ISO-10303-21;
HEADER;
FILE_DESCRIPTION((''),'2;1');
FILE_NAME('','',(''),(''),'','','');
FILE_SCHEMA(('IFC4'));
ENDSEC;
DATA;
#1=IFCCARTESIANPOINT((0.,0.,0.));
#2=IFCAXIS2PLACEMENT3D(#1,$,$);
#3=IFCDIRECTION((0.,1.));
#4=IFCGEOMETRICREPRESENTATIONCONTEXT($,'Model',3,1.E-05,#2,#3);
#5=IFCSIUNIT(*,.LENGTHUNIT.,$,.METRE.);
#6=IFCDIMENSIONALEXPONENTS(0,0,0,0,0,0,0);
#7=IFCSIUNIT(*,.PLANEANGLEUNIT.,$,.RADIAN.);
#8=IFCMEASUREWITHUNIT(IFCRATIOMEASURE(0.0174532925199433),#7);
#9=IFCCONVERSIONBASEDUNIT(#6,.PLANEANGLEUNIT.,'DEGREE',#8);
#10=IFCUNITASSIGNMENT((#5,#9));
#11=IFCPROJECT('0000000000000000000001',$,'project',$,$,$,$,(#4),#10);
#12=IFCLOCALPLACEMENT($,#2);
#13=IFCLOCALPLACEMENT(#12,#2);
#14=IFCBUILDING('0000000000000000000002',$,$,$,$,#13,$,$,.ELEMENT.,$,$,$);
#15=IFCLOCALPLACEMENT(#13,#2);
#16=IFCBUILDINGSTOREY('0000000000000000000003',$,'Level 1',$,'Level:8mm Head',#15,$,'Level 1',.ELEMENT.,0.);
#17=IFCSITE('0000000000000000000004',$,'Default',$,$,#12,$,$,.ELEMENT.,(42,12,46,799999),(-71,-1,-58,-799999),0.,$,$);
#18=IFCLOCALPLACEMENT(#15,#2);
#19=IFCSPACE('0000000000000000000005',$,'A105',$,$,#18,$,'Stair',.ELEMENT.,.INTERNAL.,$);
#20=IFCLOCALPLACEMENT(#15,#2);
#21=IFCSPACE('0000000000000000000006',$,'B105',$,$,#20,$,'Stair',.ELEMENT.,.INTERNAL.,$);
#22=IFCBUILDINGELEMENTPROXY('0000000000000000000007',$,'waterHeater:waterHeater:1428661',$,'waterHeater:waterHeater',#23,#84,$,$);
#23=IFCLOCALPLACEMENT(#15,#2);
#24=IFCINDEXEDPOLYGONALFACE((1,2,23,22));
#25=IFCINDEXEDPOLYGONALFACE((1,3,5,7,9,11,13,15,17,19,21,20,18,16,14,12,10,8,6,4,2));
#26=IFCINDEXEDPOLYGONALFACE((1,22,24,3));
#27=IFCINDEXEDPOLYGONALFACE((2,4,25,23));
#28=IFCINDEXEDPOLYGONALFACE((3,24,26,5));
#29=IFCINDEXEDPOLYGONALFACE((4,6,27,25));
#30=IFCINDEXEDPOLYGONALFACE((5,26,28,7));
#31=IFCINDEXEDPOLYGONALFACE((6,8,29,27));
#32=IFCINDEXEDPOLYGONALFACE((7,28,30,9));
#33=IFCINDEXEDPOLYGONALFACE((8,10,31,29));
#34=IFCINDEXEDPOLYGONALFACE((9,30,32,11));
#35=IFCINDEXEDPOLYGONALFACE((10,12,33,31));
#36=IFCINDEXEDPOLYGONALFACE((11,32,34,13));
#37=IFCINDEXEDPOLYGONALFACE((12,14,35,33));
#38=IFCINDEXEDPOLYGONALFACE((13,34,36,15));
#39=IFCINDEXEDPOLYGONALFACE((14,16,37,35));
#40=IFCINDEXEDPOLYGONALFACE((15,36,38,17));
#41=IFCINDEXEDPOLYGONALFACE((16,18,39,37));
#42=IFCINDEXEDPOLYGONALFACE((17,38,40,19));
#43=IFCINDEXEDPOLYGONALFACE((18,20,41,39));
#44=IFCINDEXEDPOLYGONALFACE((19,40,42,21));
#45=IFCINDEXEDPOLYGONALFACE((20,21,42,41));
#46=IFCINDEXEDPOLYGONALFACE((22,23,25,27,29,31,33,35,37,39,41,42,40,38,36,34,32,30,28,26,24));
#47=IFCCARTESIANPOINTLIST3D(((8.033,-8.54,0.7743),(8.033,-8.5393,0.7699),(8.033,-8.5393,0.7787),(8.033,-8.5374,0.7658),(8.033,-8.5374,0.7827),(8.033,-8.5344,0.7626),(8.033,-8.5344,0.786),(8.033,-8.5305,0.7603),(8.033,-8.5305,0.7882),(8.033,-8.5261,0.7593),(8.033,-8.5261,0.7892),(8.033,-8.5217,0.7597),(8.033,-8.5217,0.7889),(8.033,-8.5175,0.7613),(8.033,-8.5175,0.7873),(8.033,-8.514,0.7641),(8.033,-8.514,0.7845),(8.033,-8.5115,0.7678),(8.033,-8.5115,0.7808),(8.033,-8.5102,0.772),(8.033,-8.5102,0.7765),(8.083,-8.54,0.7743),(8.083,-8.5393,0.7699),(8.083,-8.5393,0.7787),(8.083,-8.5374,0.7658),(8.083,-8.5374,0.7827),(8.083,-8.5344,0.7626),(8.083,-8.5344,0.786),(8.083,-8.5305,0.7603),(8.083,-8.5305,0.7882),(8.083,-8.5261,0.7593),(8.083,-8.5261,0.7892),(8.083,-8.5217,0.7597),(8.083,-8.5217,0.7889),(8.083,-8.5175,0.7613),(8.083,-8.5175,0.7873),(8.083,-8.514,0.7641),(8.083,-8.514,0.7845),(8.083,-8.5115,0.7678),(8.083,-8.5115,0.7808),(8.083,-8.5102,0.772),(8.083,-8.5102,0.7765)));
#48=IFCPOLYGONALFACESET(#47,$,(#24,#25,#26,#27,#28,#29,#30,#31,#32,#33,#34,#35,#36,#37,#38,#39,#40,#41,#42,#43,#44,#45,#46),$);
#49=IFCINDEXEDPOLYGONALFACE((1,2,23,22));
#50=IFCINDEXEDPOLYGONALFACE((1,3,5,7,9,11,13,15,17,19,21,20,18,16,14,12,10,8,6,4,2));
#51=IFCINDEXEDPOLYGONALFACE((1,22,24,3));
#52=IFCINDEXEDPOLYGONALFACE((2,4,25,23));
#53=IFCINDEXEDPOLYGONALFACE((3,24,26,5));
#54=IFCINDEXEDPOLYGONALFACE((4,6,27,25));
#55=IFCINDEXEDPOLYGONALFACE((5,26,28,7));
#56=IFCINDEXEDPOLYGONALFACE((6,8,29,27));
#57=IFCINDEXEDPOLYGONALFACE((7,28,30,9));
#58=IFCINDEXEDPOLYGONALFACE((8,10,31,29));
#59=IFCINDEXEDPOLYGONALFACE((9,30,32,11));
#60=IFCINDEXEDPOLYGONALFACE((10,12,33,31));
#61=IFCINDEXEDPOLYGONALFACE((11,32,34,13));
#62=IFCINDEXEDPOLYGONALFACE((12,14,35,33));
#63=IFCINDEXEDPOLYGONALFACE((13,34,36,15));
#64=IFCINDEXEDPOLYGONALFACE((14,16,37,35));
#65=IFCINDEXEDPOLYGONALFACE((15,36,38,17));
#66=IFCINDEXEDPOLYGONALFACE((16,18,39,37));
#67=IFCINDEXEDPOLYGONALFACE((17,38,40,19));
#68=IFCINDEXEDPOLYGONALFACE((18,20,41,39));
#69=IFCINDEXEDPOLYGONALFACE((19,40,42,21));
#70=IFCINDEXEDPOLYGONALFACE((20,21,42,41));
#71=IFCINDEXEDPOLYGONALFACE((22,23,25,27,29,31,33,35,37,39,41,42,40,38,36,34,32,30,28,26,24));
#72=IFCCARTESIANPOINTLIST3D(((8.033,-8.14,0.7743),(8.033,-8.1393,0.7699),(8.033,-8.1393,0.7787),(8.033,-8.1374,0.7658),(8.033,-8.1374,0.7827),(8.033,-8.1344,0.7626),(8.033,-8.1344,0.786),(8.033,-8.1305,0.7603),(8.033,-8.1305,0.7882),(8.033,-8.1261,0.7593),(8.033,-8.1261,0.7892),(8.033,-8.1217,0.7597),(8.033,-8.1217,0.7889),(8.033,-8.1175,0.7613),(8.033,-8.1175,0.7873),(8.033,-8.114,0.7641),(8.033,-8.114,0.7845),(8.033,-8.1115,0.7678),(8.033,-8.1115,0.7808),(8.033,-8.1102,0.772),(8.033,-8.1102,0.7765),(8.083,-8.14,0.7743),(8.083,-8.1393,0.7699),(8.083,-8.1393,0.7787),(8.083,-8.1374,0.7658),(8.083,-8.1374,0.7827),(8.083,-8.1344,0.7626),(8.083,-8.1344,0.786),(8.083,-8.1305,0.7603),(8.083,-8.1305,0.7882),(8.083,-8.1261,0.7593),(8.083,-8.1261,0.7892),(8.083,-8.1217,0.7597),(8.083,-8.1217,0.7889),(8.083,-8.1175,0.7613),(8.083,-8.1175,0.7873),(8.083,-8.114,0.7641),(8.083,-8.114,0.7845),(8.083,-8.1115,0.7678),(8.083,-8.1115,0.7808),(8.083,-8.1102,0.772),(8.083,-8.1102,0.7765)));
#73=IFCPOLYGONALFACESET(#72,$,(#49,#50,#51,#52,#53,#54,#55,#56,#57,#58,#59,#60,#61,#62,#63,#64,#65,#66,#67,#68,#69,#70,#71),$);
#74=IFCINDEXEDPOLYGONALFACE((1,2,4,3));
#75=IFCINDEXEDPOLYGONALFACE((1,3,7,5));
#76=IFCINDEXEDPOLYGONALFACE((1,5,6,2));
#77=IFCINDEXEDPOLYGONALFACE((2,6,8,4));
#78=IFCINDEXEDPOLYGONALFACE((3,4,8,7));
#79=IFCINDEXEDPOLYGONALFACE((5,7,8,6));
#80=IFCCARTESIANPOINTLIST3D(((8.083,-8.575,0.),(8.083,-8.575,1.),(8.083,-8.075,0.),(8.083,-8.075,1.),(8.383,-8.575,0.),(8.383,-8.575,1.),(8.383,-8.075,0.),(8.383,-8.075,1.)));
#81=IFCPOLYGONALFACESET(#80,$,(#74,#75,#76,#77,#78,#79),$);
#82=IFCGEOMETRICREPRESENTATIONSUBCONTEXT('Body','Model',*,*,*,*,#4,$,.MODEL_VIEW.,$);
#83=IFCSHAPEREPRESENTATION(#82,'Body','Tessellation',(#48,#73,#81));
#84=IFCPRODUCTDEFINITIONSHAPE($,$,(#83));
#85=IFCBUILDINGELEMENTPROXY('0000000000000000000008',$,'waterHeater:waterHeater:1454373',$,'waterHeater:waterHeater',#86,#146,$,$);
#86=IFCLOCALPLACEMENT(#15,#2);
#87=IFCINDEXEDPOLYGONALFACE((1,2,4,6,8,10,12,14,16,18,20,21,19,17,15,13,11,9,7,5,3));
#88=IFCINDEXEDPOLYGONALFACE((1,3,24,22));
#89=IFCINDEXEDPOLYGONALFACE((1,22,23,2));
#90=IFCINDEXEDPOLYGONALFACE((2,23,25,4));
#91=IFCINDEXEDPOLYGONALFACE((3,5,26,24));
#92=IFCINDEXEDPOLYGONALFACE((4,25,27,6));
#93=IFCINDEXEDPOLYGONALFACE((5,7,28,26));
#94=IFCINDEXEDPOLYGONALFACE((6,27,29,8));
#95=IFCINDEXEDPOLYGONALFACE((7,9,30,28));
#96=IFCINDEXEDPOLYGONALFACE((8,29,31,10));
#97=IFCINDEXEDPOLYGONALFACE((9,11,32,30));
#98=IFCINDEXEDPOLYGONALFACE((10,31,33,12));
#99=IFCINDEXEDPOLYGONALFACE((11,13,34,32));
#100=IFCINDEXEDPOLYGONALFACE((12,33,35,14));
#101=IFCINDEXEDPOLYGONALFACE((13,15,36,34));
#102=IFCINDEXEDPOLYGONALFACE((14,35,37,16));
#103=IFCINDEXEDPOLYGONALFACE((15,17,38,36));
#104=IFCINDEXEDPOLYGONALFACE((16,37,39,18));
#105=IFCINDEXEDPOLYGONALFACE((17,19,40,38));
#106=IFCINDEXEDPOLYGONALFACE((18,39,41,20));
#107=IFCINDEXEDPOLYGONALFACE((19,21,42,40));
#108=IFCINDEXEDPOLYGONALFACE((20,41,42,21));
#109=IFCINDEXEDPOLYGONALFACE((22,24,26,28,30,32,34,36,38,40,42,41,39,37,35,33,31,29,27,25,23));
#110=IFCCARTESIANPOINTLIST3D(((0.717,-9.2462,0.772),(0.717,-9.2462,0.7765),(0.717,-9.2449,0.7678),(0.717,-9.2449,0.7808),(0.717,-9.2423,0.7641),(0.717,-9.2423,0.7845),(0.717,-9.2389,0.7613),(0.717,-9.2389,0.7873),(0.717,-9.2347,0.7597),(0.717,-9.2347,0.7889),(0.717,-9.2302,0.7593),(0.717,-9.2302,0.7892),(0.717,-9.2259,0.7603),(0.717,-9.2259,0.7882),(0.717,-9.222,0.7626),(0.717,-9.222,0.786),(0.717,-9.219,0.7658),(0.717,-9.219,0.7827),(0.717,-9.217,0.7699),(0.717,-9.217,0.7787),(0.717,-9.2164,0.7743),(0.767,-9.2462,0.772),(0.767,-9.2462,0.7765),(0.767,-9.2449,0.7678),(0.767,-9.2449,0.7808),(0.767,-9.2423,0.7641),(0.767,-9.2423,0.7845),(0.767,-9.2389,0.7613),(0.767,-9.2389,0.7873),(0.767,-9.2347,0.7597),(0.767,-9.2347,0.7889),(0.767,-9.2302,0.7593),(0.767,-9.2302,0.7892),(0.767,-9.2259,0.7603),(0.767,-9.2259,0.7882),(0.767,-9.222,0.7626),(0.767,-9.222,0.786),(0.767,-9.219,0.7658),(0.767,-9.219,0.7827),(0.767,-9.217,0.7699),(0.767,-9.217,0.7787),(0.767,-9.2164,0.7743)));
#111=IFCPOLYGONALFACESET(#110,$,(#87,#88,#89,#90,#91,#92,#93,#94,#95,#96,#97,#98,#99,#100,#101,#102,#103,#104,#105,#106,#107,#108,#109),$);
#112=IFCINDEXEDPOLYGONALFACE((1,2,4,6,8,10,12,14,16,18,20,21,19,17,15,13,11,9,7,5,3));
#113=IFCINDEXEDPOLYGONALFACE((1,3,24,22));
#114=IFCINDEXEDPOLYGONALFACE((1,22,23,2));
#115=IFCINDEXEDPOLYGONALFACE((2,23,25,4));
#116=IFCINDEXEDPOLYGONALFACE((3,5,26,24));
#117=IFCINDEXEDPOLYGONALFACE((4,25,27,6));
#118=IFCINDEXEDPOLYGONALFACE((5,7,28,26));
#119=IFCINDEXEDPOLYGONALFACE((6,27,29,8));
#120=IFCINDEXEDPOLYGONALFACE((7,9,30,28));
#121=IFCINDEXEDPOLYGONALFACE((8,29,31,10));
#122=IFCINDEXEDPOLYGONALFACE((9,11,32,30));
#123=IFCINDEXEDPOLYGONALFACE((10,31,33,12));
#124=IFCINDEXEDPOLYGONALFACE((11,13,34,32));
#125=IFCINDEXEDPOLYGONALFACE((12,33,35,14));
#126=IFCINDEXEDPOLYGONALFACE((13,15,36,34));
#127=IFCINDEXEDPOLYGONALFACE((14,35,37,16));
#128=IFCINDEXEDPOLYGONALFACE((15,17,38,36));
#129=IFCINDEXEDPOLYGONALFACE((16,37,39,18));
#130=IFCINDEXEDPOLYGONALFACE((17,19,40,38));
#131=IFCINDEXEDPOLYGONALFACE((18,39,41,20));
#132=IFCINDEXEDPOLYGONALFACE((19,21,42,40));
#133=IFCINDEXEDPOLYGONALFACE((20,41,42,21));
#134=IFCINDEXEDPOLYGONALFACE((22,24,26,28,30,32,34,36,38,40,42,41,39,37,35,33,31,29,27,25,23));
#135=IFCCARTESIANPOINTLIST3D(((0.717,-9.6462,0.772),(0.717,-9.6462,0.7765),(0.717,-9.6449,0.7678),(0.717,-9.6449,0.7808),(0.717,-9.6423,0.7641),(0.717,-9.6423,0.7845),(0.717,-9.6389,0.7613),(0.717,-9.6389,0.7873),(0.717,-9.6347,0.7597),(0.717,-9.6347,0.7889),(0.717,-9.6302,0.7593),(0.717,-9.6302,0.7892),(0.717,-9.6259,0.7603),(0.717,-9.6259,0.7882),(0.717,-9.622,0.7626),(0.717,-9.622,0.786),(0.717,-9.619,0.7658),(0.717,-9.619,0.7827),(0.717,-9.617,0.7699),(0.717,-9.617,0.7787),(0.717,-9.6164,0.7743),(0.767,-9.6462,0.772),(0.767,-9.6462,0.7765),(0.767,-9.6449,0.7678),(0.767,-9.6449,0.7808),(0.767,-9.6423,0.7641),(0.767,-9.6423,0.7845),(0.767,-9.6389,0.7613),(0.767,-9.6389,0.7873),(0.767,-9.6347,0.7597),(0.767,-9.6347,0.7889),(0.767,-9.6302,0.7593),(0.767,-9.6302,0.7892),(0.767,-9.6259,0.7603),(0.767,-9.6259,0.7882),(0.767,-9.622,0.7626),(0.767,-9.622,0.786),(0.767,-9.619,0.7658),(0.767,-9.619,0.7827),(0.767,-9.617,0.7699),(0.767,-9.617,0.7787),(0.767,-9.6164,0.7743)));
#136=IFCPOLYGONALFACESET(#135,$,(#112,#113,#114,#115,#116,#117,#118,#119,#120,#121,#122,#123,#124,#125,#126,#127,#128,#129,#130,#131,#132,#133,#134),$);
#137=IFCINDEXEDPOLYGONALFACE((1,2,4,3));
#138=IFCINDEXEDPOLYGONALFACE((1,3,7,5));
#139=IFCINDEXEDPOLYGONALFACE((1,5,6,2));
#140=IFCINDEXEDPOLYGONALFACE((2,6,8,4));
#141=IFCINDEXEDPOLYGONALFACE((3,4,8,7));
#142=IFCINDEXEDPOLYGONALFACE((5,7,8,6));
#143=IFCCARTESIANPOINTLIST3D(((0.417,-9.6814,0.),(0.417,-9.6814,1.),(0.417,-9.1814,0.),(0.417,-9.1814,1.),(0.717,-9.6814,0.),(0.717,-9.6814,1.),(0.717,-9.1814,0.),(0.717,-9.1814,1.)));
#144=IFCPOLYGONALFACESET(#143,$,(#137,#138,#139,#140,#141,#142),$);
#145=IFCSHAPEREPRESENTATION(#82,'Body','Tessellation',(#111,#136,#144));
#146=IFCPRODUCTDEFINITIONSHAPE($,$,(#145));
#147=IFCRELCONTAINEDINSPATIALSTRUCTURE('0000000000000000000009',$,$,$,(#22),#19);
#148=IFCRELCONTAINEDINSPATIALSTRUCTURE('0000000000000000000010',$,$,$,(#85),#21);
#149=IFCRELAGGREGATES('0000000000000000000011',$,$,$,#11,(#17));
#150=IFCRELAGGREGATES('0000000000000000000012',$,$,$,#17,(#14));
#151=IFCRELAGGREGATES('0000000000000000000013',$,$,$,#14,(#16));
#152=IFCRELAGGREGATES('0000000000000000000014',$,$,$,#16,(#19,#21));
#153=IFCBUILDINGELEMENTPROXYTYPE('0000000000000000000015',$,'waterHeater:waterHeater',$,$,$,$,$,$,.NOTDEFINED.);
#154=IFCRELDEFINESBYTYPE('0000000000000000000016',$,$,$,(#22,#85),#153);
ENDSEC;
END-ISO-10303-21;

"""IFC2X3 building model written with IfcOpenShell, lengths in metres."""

from ifc_helpers import new_model, entity, si_unit, converted_unit, direction, frame, frame_2d, origin, origin_2d_with_axis, place, context, subcontext, project, spatial, rectangle, circle, extrude, source, transform, mapped, type_object, type_shapes, element, save


model = new_model("IFC2X3")

# Units and contexts
model_context = context("Model", 3, precision=1e-05, world=origin(), true_north=direction((0.0, 1.0)))
body_context = subcontext(model_context, "Body", "Model", "MODEL_VIEW")
ifc_project = project(units=[si_unit("LENGTHUNIT", "METRE"), converted_unit("PLANEANGLEUNIT", "DEGREE", entity("IfcRatioMeasure", 0.0174532925199433), si_unit("PLANEANGLEUNIT", "RADIAN"), dimensions=[0, 0, 0, 0, 0, 0, 0])], contexts=[model_context])

# Site, building, storey
site_placement = place(None, origin())
site = spatial("IfcSite", under=ifc_project, at=site_placement, Name="Default", CompositionType="ELEMENT", RefLatitude=(42, 12, 46, 799999), RefLongitude=(-71, -1, -58, -799999), RefElevation=0.0)
building_placement = place(site_placement, origin())
building = spatial("IfcBuilding", under=site, at=building_placement, CompositionType="ELEMENT")
storey_placement = place(building_placement, origin())
storey = spatial("IfcBuildingStorey", under=building, at=storey_placement, Name="Level 1", ObjectType="Level:8mm Head", LongName="Level 1", CompositionType="ELEMENT", Elevation=0.0)

# Shared definitions
space_1_placement = place(storey_placement, origin())
space_1 = spatial("IfcSpace", under=storey, at=space_1_placement, Name="A105", LongName="Stair", CompositionType="ELEMENT", InteriorOrExteriorSpace="INTERNAL")

# Building element proxy
building_element_proxy_type = type_object("IfcBuildingElementProxyType", Name="waterHeater:waterHeater", PredefinedType="NOTDEFINED")
shared_shape_1 = source(origin(), body_context, "Body", "SweptSolid", [
    extrude(circle(Radius=0.015, at=frame_2d((0.0, 0.0), x_axis=(1.0, 0.0))), frame((0.2, -0.2, 0.7743), z_axis=(0.0, 1.0, 0.0), x_axis=(1.0, 0.0, 0.0)), (0.0, 0.0, 1.0), 0.05),
    extrude(circle(Radius=0.015, at=frame_2d((0.0, 0.0), x_axis=(1.0, 0.0))), frame((-0.2, -0.2, 0.7743), z_axis=(0.0, 1.0, 0.0), x_axis=(1.0, 0.0, 0.0)), (0.0, 0.0, 1.0), 0.05),
    extrude(rectangle(XDim=0.5, YDim=0.3, at=origin_2d_with_axis()), frame((0.0, 0.0, 0.0), z_axis=(0.0, 0.0, 1.0), x_axis=(-1.0, 0.0, 0.0)), (0.0, 0.0, 1.0), 1.0),
])
type_shapes(building_element_proxy_type, [shared_shape_1])
proxy_1_placement = place(space_1_placement, frame((8.233, -8.325, 0.0), z_axis=(0.0, 0.0, 1.0), x_axis=(0.0, -1.0, 0.0)))
element("IfcBuildingElementProxy", 1, at=proxy_1_placement, inside=space_1, type_object=building_element_proxy_type, Name="waterHeater:waterHeater:1428661", ObjectType="waterHeater:waterHeater", context=body_context, shape_type="MappedRepresentation", body=[
    mapped(shared_shape_1, transform((0.0, 0.0, 0.0), scale=1.0)),
])

# Shared definitions
space_2_placement = place(storey_placement, origin())
space_2 = spatial("IfcSpace", under=storey, at=space_2_placement, Name="B105", LongName="Stair", CompositionType="ELEMENT", InteriorOrExteriorSpace="INTERNAL")

# Building element proxy
proxy_2_placement = place(space_2_placement, frame((0.567, -9.4314, 0.0), z_axis=(0.0, 0.0, 1.0), x_axis=(0.0, 1.0, 0.0)))
element("IfcBuildingElementProxy", 2, at=proxy_2_placement, inside=space_2, type_object=building_element_proxy_type, Name="waterHeater:waterHeater:1454373", ObjectType="waterHeater:waterHeater", context=body_context, shape_type="MappedRepresentation", body=[
    mapped(shared_shape_1, transform((0.0, 0.0, 0.0), scale=1.0)),
])

save(model, "model.ifc")
